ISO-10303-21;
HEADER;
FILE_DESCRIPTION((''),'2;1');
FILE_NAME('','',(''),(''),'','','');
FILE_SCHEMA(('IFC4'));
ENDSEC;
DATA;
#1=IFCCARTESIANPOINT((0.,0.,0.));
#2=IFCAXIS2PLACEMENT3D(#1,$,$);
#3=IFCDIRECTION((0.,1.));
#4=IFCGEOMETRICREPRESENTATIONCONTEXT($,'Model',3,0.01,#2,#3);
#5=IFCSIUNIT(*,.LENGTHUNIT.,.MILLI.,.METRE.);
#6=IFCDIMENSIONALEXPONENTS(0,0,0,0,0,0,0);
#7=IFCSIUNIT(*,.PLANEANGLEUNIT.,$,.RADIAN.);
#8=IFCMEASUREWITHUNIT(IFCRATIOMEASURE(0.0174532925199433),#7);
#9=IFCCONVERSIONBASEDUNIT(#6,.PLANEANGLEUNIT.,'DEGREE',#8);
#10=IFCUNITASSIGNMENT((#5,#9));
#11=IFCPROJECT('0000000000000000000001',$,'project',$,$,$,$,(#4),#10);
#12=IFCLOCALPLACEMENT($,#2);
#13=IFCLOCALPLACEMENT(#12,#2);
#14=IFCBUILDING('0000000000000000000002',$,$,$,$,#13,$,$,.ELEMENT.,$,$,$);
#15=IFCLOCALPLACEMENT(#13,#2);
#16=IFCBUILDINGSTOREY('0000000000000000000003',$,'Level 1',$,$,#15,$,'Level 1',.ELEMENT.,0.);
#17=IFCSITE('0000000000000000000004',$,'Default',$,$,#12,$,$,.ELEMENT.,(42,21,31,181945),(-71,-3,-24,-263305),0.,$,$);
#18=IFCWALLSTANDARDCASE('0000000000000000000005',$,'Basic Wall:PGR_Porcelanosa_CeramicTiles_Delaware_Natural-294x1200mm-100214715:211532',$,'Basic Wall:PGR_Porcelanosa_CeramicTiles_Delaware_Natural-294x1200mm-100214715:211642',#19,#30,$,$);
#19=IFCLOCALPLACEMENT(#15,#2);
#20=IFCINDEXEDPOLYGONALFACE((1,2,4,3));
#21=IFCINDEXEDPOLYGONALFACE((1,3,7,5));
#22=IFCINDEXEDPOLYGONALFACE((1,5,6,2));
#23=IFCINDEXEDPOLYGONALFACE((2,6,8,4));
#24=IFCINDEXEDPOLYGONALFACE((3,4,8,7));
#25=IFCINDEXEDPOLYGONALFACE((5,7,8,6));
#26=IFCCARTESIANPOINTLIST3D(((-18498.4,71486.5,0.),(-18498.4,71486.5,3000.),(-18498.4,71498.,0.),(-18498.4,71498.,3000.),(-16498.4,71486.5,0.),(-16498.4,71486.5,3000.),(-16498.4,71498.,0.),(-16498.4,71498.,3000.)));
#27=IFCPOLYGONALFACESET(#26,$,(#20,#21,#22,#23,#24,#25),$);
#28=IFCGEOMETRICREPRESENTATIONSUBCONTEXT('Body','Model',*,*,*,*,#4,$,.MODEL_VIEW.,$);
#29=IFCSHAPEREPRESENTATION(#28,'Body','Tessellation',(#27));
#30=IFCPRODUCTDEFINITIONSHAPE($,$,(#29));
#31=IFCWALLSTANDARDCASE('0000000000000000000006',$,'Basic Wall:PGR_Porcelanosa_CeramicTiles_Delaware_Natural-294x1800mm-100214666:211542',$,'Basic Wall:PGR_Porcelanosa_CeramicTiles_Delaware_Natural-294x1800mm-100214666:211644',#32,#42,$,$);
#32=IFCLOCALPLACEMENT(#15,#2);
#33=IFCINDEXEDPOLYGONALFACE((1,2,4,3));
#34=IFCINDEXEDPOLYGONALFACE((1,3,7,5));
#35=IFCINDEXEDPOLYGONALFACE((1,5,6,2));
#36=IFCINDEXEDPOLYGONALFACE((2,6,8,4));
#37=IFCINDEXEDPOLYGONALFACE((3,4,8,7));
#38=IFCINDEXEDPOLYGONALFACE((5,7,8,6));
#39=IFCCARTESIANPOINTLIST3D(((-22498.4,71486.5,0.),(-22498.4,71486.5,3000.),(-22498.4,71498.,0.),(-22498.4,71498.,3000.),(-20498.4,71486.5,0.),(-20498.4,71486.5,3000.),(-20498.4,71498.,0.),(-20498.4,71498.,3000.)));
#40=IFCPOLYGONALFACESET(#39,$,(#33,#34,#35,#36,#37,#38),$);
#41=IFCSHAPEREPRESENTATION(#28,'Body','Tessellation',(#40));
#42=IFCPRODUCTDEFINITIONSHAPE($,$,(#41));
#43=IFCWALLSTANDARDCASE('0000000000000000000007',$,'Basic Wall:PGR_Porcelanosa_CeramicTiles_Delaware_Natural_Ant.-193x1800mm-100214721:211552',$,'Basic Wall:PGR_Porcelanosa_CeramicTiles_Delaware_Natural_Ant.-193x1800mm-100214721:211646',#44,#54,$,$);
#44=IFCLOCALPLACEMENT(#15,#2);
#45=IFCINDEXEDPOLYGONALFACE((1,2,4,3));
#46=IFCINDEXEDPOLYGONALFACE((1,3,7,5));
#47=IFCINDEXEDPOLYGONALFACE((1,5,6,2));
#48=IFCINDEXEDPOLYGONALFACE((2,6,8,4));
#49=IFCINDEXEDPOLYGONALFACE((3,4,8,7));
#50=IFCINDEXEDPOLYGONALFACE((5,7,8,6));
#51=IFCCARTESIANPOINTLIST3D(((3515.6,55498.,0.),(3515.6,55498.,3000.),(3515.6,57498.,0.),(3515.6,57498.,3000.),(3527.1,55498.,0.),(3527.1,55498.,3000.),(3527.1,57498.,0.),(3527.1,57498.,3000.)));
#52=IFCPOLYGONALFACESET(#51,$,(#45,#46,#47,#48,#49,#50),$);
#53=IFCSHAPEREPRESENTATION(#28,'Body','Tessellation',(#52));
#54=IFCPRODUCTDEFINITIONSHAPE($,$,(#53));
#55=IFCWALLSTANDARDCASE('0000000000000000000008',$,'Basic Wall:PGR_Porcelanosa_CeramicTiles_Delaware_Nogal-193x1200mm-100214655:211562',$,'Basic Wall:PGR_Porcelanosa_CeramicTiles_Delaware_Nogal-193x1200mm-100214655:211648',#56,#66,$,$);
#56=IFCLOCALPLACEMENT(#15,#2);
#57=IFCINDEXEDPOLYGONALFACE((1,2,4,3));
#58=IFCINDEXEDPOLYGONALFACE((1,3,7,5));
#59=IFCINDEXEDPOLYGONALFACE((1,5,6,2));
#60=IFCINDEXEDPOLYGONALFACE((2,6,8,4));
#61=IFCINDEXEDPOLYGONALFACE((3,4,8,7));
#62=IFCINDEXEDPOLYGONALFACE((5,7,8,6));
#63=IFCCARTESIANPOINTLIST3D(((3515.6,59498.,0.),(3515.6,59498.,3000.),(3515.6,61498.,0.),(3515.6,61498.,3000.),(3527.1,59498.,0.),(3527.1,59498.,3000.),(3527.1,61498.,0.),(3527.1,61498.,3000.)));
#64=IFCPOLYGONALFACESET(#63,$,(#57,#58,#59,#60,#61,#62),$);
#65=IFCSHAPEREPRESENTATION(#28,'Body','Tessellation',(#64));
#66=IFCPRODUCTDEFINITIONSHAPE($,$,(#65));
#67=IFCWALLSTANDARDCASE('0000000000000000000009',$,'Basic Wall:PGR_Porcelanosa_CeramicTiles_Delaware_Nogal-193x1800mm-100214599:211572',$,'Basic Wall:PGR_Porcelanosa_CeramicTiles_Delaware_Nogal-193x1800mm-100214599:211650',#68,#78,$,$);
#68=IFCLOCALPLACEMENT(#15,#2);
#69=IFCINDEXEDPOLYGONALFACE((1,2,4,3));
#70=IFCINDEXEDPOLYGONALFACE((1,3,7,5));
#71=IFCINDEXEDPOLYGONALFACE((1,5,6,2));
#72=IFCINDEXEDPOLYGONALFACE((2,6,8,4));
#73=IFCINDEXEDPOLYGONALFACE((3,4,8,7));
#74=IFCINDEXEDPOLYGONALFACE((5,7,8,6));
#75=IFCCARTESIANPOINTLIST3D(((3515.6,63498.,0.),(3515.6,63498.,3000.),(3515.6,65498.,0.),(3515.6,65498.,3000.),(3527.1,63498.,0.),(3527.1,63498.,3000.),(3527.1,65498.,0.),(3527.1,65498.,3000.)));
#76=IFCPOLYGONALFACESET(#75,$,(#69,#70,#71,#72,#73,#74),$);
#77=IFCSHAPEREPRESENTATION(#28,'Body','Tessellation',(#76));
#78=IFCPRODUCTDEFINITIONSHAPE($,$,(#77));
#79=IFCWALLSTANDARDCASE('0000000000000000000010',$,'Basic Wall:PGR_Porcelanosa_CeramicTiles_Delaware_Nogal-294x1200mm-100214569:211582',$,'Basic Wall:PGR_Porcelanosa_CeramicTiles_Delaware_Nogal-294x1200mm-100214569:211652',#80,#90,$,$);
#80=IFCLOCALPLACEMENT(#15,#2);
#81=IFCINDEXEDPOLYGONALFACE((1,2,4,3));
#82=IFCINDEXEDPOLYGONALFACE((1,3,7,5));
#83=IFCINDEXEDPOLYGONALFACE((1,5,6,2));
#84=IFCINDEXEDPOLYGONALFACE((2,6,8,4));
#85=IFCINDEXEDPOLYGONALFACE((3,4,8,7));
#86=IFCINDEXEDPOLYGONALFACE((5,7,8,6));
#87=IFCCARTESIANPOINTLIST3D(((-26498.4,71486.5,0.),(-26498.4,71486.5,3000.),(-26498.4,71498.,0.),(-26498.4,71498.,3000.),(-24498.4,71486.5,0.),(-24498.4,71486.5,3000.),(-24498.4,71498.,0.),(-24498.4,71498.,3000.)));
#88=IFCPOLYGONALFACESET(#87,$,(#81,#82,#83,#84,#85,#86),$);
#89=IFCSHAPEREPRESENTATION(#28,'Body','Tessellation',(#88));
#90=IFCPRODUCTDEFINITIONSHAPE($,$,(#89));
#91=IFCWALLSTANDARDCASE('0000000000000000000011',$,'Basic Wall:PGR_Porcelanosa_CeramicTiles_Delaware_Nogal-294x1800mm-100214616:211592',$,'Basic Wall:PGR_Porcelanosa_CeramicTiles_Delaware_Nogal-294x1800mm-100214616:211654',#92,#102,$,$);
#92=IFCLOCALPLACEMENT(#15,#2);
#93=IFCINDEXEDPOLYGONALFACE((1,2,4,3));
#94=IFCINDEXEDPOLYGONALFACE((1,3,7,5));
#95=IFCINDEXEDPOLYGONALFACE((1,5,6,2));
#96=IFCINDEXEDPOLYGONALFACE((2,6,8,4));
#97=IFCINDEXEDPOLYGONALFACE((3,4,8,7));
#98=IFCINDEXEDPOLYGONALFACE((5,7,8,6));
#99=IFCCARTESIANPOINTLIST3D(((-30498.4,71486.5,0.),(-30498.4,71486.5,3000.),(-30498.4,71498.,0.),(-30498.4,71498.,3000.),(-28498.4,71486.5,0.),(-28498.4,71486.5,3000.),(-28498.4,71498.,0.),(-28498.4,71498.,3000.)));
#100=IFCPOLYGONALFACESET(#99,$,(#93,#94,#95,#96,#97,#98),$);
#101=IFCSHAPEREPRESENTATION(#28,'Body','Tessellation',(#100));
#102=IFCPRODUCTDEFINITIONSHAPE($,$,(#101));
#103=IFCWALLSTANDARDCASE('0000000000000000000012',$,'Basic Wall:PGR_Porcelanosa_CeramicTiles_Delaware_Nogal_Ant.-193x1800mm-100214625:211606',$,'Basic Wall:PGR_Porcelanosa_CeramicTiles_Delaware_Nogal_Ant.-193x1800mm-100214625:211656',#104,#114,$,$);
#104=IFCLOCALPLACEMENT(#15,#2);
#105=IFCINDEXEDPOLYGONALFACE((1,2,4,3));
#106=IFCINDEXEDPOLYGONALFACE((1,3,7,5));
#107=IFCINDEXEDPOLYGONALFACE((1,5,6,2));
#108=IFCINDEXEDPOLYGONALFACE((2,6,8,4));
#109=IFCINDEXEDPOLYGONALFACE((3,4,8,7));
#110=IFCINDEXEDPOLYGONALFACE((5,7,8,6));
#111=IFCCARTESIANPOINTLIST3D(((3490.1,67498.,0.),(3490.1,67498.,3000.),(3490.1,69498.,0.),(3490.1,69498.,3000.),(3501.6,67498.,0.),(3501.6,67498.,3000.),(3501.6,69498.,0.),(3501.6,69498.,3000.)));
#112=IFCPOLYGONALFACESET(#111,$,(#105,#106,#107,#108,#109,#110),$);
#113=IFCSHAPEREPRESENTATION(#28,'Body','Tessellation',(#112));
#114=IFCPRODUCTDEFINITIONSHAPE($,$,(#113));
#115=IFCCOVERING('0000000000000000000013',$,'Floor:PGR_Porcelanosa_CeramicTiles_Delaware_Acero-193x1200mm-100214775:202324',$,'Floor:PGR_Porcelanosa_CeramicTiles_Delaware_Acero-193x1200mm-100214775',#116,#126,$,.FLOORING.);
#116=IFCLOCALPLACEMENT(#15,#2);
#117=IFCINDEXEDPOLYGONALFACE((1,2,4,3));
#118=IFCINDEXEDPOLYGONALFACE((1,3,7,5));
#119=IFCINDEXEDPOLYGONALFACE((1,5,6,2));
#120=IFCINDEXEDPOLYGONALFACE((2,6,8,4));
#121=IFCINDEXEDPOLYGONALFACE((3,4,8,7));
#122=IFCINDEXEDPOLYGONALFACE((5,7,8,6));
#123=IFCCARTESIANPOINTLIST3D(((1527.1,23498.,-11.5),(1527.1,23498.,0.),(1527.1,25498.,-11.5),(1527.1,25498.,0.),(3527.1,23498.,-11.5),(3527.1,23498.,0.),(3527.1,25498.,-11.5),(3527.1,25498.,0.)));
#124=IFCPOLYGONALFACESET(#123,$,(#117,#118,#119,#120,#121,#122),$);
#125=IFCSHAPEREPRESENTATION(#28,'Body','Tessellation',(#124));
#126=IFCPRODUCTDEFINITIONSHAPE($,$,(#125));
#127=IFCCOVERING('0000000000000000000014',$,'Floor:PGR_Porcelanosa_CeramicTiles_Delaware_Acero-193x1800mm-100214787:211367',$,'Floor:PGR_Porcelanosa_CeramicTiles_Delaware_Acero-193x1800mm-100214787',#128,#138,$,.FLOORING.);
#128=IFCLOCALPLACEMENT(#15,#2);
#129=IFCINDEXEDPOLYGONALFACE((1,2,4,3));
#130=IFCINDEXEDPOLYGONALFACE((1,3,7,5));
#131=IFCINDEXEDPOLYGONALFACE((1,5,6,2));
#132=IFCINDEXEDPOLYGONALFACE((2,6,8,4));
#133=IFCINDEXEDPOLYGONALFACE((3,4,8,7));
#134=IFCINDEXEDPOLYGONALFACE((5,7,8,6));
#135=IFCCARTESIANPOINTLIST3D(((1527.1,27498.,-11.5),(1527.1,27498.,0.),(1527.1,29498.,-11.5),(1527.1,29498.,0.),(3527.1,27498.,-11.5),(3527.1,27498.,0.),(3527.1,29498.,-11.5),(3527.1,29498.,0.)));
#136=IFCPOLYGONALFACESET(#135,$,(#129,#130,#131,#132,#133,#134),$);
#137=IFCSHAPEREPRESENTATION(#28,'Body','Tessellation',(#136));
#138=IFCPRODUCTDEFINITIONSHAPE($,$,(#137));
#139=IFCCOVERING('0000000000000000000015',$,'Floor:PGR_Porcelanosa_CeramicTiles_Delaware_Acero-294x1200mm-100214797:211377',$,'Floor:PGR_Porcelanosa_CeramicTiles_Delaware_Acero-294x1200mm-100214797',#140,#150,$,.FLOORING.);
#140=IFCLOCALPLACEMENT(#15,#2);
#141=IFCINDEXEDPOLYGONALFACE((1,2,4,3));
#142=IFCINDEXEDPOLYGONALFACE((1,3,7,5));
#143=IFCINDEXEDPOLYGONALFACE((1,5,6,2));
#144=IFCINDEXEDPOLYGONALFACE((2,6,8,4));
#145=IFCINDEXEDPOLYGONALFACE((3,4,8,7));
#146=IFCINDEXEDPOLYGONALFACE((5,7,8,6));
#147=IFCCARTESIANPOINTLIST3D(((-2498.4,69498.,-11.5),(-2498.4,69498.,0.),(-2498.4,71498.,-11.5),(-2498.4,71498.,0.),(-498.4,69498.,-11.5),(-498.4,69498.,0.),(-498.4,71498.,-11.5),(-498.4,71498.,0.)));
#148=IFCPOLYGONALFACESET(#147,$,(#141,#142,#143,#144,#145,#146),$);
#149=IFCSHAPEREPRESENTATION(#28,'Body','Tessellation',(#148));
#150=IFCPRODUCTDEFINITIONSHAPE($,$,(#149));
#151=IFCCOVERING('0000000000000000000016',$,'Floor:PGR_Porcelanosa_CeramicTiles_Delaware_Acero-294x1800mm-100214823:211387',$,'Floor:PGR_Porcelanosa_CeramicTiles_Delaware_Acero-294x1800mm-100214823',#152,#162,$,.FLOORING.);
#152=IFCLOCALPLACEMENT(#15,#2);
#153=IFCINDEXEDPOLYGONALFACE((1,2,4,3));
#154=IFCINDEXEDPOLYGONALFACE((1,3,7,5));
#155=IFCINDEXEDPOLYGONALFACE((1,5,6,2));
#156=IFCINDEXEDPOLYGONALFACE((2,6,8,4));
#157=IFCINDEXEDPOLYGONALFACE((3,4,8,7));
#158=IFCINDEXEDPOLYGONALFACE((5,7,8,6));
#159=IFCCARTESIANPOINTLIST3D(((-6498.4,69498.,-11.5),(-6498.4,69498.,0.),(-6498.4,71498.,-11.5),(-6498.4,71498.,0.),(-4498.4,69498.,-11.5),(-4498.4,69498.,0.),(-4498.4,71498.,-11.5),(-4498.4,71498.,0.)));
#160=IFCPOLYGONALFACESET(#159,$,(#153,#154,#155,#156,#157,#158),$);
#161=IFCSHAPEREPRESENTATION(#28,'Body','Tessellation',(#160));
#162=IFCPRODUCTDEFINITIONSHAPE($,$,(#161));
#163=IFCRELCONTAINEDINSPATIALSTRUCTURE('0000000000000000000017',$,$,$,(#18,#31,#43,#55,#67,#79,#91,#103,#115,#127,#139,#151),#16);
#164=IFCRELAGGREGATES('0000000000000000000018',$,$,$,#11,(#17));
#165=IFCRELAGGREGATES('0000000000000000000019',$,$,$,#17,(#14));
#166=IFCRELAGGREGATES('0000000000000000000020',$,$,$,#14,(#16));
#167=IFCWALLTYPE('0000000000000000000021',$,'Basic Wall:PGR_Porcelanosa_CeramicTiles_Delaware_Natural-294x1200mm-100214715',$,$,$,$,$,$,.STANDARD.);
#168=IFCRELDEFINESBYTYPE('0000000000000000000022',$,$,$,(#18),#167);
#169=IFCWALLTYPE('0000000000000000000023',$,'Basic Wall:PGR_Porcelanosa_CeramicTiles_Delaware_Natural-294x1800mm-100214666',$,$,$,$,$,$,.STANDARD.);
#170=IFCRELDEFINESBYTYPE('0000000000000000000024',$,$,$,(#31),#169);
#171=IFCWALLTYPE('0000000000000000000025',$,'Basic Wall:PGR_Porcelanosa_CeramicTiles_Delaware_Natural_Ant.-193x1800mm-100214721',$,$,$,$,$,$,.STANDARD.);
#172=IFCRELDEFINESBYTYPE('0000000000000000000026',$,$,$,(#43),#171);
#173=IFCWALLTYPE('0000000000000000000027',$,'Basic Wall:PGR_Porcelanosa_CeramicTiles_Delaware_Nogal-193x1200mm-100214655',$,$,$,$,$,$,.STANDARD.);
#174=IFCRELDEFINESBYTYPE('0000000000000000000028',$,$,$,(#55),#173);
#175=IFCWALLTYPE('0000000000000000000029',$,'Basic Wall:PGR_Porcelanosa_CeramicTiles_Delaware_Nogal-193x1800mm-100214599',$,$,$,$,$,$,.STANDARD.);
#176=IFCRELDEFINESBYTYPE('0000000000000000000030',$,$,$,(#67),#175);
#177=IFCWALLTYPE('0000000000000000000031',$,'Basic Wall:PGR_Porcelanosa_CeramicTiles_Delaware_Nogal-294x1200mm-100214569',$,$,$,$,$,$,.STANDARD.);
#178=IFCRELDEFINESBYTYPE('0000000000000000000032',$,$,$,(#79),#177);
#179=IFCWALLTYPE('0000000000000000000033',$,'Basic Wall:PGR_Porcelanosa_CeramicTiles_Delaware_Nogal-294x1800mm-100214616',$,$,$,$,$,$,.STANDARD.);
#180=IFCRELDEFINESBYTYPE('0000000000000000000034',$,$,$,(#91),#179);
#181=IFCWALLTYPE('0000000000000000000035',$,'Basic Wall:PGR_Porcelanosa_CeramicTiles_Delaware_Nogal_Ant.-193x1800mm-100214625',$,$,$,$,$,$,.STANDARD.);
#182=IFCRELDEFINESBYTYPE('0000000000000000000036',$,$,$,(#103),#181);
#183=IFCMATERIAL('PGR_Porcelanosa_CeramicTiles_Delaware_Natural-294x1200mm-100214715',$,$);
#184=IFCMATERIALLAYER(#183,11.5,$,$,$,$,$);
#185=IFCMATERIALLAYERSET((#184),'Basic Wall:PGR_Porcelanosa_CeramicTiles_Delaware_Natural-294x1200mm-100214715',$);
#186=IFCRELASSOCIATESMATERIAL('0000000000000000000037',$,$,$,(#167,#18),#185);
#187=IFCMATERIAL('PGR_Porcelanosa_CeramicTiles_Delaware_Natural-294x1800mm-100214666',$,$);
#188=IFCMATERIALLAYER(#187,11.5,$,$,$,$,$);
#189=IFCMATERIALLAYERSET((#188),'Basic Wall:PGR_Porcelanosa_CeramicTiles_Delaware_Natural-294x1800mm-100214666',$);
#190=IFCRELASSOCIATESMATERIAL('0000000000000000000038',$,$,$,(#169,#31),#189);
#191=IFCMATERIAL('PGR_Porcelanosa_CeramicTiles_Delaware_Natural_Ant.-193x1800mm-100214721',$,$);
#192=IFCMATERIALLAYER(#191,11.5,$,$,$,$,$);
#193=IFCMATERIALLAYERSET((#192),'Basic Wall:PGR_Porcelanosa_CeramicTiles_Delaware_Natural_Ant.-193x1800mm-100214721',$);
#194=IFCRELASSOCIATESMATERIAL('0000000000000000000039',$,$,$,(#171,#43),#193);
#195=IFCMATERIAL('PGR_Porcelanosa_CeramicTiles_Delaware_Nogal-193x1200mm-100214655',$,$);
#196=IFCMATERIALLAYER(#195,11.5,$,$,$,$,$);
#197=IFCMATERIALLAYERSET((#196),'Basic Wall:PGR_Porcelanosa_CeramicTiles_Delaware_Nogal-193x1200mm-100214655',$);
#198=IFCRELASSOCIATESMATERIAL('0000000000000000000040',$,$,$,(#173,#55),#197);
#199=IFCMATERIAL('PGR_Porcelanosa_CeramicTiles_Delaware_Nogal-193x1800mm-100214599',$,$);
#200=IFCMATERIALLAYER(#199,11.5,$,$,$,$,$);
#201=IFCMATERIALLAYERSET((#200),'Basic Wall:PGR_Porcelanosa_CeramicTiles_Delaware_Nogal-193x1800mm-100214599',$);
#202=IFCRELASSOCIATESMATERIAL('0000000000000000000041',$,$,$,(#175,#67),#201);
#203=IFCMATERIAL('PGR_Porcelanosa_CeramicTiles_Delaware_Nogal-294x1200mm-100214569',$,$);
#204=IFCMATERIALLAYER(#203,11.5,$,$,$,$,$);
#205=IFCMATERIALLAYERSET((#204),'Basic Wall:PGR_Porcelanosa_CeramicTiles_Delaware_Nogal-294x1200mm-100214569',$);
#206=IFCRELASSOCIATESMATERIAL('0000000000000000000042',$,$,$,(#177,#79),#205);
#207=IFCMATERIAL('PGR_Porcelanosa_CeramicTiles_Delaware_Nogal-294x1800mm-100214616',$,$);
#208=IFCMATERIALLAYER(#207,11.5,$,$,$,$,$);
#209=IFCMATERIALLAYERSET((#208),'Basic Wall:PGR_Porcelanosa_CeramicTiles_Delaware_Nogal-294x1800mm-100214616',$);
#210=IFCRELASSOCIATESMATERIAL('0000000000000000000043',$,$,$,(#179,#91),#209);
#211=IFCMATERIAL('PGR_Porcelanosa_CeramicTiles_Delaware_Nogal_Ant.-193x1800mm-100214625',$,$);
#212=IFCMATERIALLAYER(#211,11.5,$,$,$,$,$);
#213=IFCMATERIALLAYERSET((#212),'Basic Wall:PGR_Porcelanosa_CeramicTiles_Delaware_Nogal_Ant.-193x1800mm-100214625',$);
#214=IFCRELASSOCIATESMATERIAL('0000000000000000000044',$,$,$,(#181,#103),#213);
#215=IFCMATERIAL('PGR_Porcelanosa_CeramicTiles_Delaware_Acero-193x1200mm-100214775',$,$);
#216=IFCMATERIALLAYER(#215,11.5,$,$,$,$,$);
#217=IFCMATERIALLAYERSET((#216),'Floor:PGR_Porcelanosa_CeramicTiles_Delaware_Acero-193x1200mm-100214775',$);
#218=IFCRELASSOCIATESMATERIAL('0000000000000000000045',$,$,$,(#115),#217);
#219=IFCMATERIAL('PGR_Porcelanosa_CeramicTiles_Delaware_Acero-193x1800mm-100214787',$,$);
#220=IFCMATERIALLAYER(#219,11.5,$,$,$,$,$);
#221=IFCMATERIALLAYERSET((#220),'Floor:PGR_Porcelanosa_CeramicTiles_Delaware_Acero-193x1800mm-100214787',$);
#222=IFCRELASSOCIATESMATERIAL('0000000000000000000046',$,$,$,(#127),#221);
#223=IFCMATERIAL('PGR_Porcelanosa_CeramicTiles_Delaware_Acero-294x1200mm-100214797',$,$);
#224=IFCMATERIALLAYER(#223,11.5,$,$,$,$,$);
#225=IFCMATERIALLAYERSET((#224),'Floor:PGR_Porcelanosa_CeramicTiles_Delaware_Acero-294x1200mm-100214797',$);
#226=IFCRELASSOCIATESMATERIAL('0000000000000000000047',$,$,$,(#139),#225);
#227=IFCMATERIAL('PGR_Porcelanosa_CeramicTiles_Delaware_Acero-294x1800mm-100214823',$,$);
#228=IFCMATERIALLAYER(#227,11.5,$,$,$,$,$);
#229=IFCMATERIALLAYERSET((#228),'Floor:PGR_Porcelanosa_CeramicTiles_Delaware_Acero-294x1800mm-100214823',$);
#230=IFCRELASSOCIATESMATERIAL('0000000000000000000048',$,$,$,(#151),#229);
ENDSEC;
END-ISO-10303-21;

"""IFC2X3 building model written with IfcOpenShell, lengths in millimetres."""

from ifc_helpers import new_model, entity, si_unit, converted_unit, direction, frame, frame_2d, origin, place, context, subcontext, project, spatial, rectangle, extrude, material, layer, layer_set, layer_usage, type_object, element, save


model = new_model("IFC2X3")

# Units and contexts
model_context = context("Model", 3, precision=0.01, world=origin(), true_north=direction((0.0, 1.0)))
body_context = subcontext(model_context, "Body", "Model", "MODEL_VIEW")
ifc_project = project(units=[si_unit("LENGTHUNIT", "METRE", prefix="MILLI"), converted_unit("PLANEANGLEUNIT", "DEGREE", entity("IfcRatioMeasure", 0.0174532925199433), si_unit("PLANEANGLEUNIT", "RADIAN"), dimensions=[0, 0, 0, 0, 0, 0, 0])], contexts=[model_context])

# Site, building, storey
site_placement = place(None, origin())
site = spatial("IfcSite", under=ifc_project, at=site_placement, Name="Default", CompositionType="ELEMENT", RefLatitude=(42, 21, 31, 181945), RefLongitude=(-71, -3, -24, -263305), RefElevation=0.0)
building_placement = place(site_placement, origin())
building = spatial("IfcBuilding", under=site, at=building_placement, CompositionType="ELEMENT")
storey_placement = place(building_placement, origin())
storey = spatial("IfcBuildingStorey", under=building, at=storey_placement, Name="Level 1", LongName="Level 1", CompositionType="ELEMENT", Elevation=0.0)

# Walls
ifc_material_1 = material(Name="PGR_Porcelanosa_CeramicTiles_Delaware_Acero-193x1200mm-100214775")
ifc_material_2 = material(Name="PGR_Porcelanosa_CeramicTiles_Delaware_Acero-193x1800mm-100214787")
ifc_material_3 = material(Name="PGR_Porcelanosa_CeramicTiles_Delaware_Acero-294x1200mm-100214797")
ifc_material_4 = material(Name="PGR_Porcelanosa_CeramicTiles_Delaware_Acero-294x1800mm-100214823")
ifc_material_5 = material(Name="PGR_Porcelanosa_CeramicTiles_Delaware_Natural-294x1200mm-100214715")
ifc_layer_1 = layer(ifc_material_5, 11.5)
ifc_layer_set_1 = layer_set([ifc_layer_1], Name="Basic Wall:PGR_Porcelanosa_CeramicTiles_Delaware_Natural-294x1200mm-100214715")
ifc_layer_usage_1 = layer_usage(ifc_layer_set_1, "AXIS2", "POSITIVE", -5.8)
wall_type_1 = type_object("IfcWallType", Name="Basic Wall:PGR_Porcelanosa_CeramicTiles_Delaware_Natural-294x1200mm-100214715", PredefinedType="STANDARD", material=ifc_layer_set_1)
wall_1_placement = place(storey_placement, frame((-18498.4, 71492.3, 0.0)))
element("IfcWallStandardCase", 1, at=wall_1_placement, inside=storey, type_object=wall_type_1, material=ifc_layer_usage_1, Name="Basic Wall:PGR_Porcelanosa_CeramicTiles_Delaware_Natural-294x1200mm-100214715:211532", ObjectType="Basic Wall:PGR_Porcelanosa_CeramicTiles_Delaware_Natural-294x1200mm-100214715:211642", context=body_context, shape_type="SweptSolid", body=[
    extrude(rectangle(XDim=2000.0, YDim=11.5, at=frame_2d((1000.0, 0.0), x_axis=(-1.0, 0.0))), origin(), (0.0, 0.0, 1.0), 3000.0),
])
ifc_material_6 = material(Name="PGR_Porcelanosa_CeramicTiles_Delaware_Natural-294x1800mm-100214666")
ifc_layer_2 = layer(ifc_material_6, 11.5)
ifc_layer_set_2 = layer_set([ifc_layer_2], Name="Basic Wall:PGR_Porcelanosa_CeramicTiles_Delaware_Natural-294x1800mm-100214666")
ifc_layer_usage_2 = layer_usage(ifc_layer_set_2, "AXIS2", "POSITIVE", -5.8)
wall_type_2 = type_object("IfcWallType", Name="Basic Wall:PGR_Porcelanosa_CeramicTiles_Delaware_Natural-294x1800mm-100214666", PredefinedType="STANDARD", material=ifc_layer_set_2)
wall_2_placement = place(storey_placement, frame((-22498.4, 71492.3, 0.0)))
element("IfcWallStandardCase", 2, at=wall_2_placement, inside=storey, type_object=wall_type_2, material=ifc_layer_usage_2, Name="Basic Wall:PGR_Porcelanosa_CeramicTiles_Delaware_Natural-294x1800mm-100214666:211542", ObjectType="Basic Wall:PGR_Porcelanosa_CeramicTiles_Delaware_Natural-294x1800mm-100214666:211644", context=body_context, shape_type="SweptSolid", body=[
    extrude(rectangle(XDim=2000.0, YDim=11.5, at=frame_2d((1000.0, 0.0), x_axis=(-1.0, 0.0))), origin(), (0.0, 0.0, 1.0), 3000.0),
])
ifc_material_7 = material(Name="PGR_Porcelanosa_CeramicTiles_Delaware_Natural_Ant.-193x1800mm-100214721")
ifc_layer_3 = layer(ifc_material_7, 11.5)
ifc_layer_set_3 = layer_set([ifc_layer_3], Name="Basic Wall:PGR_Porcelanosa_CeramicTiles_Delaware_Natural_Ant.-193x1800mm-100214721")
ifc_layer_usage_3 = layer_usage(ifc_layer_set_3, "AXIS2", "POSITIVE", -5.8)
wall_type_3 = type_object("IfcWallType", Name="Basic Wall:PGR_Porcelanosa_CeramicTiles_Delaware_Natural_Ant.-193x1800mm-100214721", PredefinedType="STANDARD", material=ifc_layer_set_3)
wall_3_placement = place(storey_placement, frame((3521.3, 57498.0, 0.0), z_axis=(0.0, 0.0, 1.0), x_axis=(0.0, -1.0, 0.0)))
element("IfcWallStandardCase", 3, at=wall_3_placement, inside=storey, type_object=wall_type_3, material=ifc_layer_usage_3, Name="Basic Wall:PGR_Porcelanosa_CeramicTiles_Delaware_Natural_Ant.-193x1800mm-100214721:211552", ObjectType="Basic Wall:PGR_Porcelanosa_CeramicTiles_Delaware_Natural_Ant.-193x1800mm-100214721:211646", context=body_context, shape_type="SweptSolid", body=[
    extrude(rectangle(XDim=2000.0, YDim=11.5, at=frame_2d((1000.0, 0.0), x_axis=(-1.0, 0.0))), origin(), (0.0, 0.0, 1.0), 3000.0),
])
ifc_material_8 = material(Name="PGR_Porcelanosa_CeramicTiles_Delaware_Nogal-193x1200mm-100214655")
ifc_layer_4 = layer(ifc_material_8, 11.5)
ifc_layer_set_4 = layer_set([ifc_layer_4], Name="Basic Wall:PGR_Porcelanosa_CeramicTiles_Delaware_Nogal-193x1200mm-100214655")
ifc_layer_usage_4 = layer_usage(ifc_layer_set_4, "AXIS2", "POSITIVE", -5.8)
wall_type_4 = type_object("IfcWallType", Name="Basic Wall:PGR_Porcelanosa_CeramicTiles_Delaware_Nogal-193x1200mm-100214655", PredefinedType="STANDARD", material=ifc_layer_set_4)
wall_4_placement = place(storey_placement, frame((3521.3, 61498.0, 0.0), z_axis=(0.0, 0.0, 1.0), x_axis=(0.0, -1.0, 0.0)))
element("IfcWallStandardCase", 4, at=wall_4_placement, inside=storey, type_object=wall_type_4, material=ifc_layer_usage_4, Name="Basic Wall:PGR_Porcelanosa_CeramicTiles_Delaware_Nogal-193x1200mm-100214655:211562", ObjectType="Basic Wall:PGR_Porcelanosa_CeramicTiles_Delaware_Nogal-193x1200mm-100214655:211648", context=body_context, shape_type="SweptSolid", body=[
    extrude(rectangle(XDim=2000.0, YDim=11.5, at=frame_2d((1000.0, 0.0), x_axis=(-1.0, 0.0))), origin(), (0.0, 0.0, 1.0), 3000.0),
])
ifc_material_9 = material(Name="PGR_Porcelanosa_CeramicTiles_Delaware_Nogal-193x1800mm-100214599")
ifc_layer_5 = layer(ifc_material_9, 11.5)
ifc_layer_set_5 = layer_set([ifc_layer_5], Name="Basic Wall:PGR_Porcelanosa_CeramicTiles_Delaware_Nogal-193x1800mm-100214599")
ifc_layer_usage_5 = layer_usage(ifc_layer_set_5, "AXIS2", "POSITIVE", -5.8)
wall_type_5 = type_object("IfcWallType", Name="Basic Wall:PGR_Porcelanosa_CeramicTiles_Delaware_Nogal-193x1800mm-100214599", PredefinedType="STANDARD", material=ifc_layer_set_5)
wall_5_placement = place(storey_placement, frame((3521.3, 65498.0, 0.0), z_axis=(0.0, 0.0, 1.0), x_axis=(0.0, -1.0, 0.0)))
element("IfcWallStandardCase", 5, at=wall_5_placement, inside=storey, type_object=wall_type_5, material=ifc_layer_usage_5, Name="Basic Wall:PGR_Porcelanosa_CeramicTiles_Delaware_Nogal-193x1800mm-100214599:211572", ObjectType="Basic Wall:PGR_Porcelanosa_CeramicTiles_Delaware_Nogal-193x1800mm-100214599:211650", context=body_context, shape_type="SweptSolid", body=[
    extrude(rectangle(XDim=2000.0, YDim=11.5, at=frame_2d((1000.0, 0.0), x_axis=(-1.0, 0.0))), origin(), (0.0, 0.0, 1.0), 3000.0),
])
ifc_material_10 = material(Name="PGR_Porcelanosa_CeramicTiles_Delaware_Nogal-294x1200mm-100214569")
ifc_layer_6 = layer(ifc_material_10, 11.5)
ifc_layer_set_6 = layer_set([ifc_layer_6], Name="Basic Wall:PGR_Porcelanosa_CeramicTiles_Delaware_Nogal-294x1200mm-100214569")
ifc_layer_usage_6 = layer_usage(ifc_layer_set_6, "AXIS2", "POSITIVE", -5.8)
wall_type_6 = type_object("IfcWallType", Name="Basic Wall:PGR_Porcelanosa_CeramicTiles_Delaware_Nogal-294x1200mm-100214569", PredefinedType="STANDARD", material=ifc_layer_set_6)
wall_6_placement = place(storey_placement, frame((-26498.4, 71492.3, 0.0)))
element("IfcWallStandardCase", 6, at=wall_6_placement, inside=storey, type_object=wall_type_6, material=ifc_layer_usage_6, Name="Basic Wall:PGR_Porcelanosa_CeramicTiles_Delaware_Nogal-294x1200mm-100214569:211582", ObjectType="Basic Wall:PGR_Porcelanosa_CeramicTiles_Delaware_Nogal-294x1200mm-100214569:211652", context=body_context, shape_type="SweptSolid", body=[
    extrude(rectangle(XDim=2000.0, YDim=11.5, at=frame_2d((1000.0, 0.0), x_axis=(-1.0, 0.0))), origin(), (0.0, 0.0, 1.0), 3000.0),
])
ifc_material_11 = material(Name="PGR_Porcelanosa_CeramicTiles_Delaware_Nogal-294x1800mm-100214616")
ifc_layer_7 = layer(ifc_material_11, 11.5)
ifc_layer_set_7 = layer_set([ifc_layer_7], Name="Basic Wall:PGR_Porcelanosa_CeramicTiles_Delaware_Nogal-294x1800mm-100214616")
ifc_layer_usage_7 = layer_usage(ifc_layer_set_7, "AXIS2", "POSITIVE", -5.8)
wall_type_7 = type_object("IfcWallType", Name="Basic Wall:PGR_Porcelanosa_CeramicTiles_Delaware_Nogal-294x1800mm-100214616", PredefinedType="STANDARD", material=ifc_layer_set_7)
wall_7_placement = place(storey_placement, frame((-30498.4, 71492.3, 0.0)))
element("IfcWallStandardCase", 7, at=wall_7_placement, inside=storey, type_object=wall_type_7, material=ifc_layer_usage_7, Name="Basic Wall:PGR_Porcelanosa_CeramicTiles_Delaware_Nogal-294x1800mm-100214616:211592", ObjectType="Basic Wall:PGR_Porcelanosa_CeramicTiles_Delaware_Nogal-294x1800mm-100214616:211654", context=body_context, shape_type="SweptSolid", body=[
    extrude(rectangle(XDim=2000.0, YDim=11.5, at=frame_2d((1000.0, 0.0), x_axis=(-1.0, 0.0))), origin(), (0.0, 0.0, 1.0), 3000.0),
])
ifc_material_12 = material(Name="PGR_Porcelanosa_CeramicTiles_Delaware_Nogal_Ant.-193x1800mm-100214625")
ifc_layer_8 = layer(ifc_material_12, 11.5)
ifc_layer_set_8 = layer_set([ifc_layer_8], Name="Basic Wall:PGR_Porcelanosa_CeramicTiles_Delaware_Nogal_Ant.-193x1800mm-100214625")
ifc_layer_usage_8 = layer_usage(ifc_layer_set_8, "AXIS2", "POSITIVE", -5.8)
wall_type_8 = type_object("IfcWallType", Name="Basic Wall:PGR_Porcelanosa_CeramicTiles_Delaware_Nogal_Ant.-193x1800mm-100214625", PredefinedType="STANDARD", material=ifc_layer_set_8)
wall_8_placement = place(storey_placement, frame((3495.8, 69498.0, 0.0), z_axis=(0.0, 0.0, 1.0), x_axis=(0.0, -1.0, 0.0)))
element("IfcWallStandardCase", 8, at=wall_8_placement, inside=storey, type_object=wall_type_8, material=ifc_layer_usage_8, Name="Basic Wall:PGR_Porcelanosa_CeramicTiles_Delaware_Nogal_Ant.-193x1800mm-100214625:211606", ObjectType="Basic Wall:PGR_Porcelanosa_CeramicTiles_Delaware_Nogal_Ant.-193x1800mm-100214625:211656", context=body_context, shape_type="SweptSolid", body=[
    extrude(rectangle(XDim=2000.0, YDim=11.5, at=frame_2d((1000.0, 0.0), x_axis=(-1.0, 0.0))), origin(), (0.0, 0.0, 1.0), 3000.0),
])

# Coverings
ifc_layer_9 = layer(ifc_material_1, 11.5)
ifc_layer_set_9 = layer_set([ifc_layer_9], Name="Floor:PGR_Porcelanosa_CeramicTiles_Delaware_Acero-193x1200mm-100214775")
ifc_layer_usage_9 = layer_usage(ifc_layer_set_9, "AXIS3", "POSITIVE", 0.0)
covering_1_placement = place(storey_placement, origin())
element("IfcCovering", 9, at=covering_1_placement, inside=storey, material=ifc_layer_usage_9, Name="Floor:PGR_Porcelanosa_CeramicTiles_Delaware_Acero-193x1200mm-100214775:202324", ObjectType="Floor:PGR_Porcelanosa_CeramicTiles_Delaware_Acero-193x1200mm-100214775", PredefinedType="FLOORING", context=body_context, shape_type="SweptSolid", body=[
    extrude(rectangle(XDim=2000.0, YDim=2000.0, at=frame_2d((0.0, 0.0), x_axis=(1.0, 0.0))), frame((2527.1, 24498.0, 0.0), z_axis=(0.0, 0.0, -1.0), x_axis=(0.0, 1.0, 0.0)), (0.0, 0.0, 1.0), 11.5),
])
ifc_layer_10 = layer(ifc_material_2, 11.5)
ifc_layer_set_10 = layer_set([ifc_layer_10], Name="Floor:PGR_Porcelanosa_CeramicTiles_Delaware_Acero-193x1800mm-100214787")
ifc_layer_usage_10 = layer_usage(ifc_layer_set_10, "AXIS3", "POSITIVE", 0.0)
covering_2_placement = place(storey_placement, origin())
element("IfcCovering", 10, at=covering_2_placement, inside=storey, material=ifc_layer_usage_10, Name="Floor:PGR_Porcelanosa_CeramicTiles_Delaware_Acero-193x1800mm-100214787:211367", ObjectType="Floor:PGR_Porcelanosa_CeramicTiles_Delaware_Acero-193x1800mm-100214787", PredefinedType="FLOORING", context=body_context, shape_type="SweptSolid", body=[
    extrude(rectangle(XDim=2000.0, YDim=2000.0, at=frame_2d((0.0, 0.0), x_axis=(1.0, 0.0))), frame((2527.1, 28498.0, 0.0), z_axis=(0.0, 0.0, -1.0), x_axis=(0.0, 1.0, 0.0)), (0.0, 0.0, 1.0), 11.5),
])
ifc_layer_11 = layer(ifc_material_3, 11.5)
ifc_layer_set_11 = layer_set([ifc_layer_11], Name="Floor:PGR_Porcelanosa_CeramicTiles_Delaware_Acero-294x1200mm-100214797")
ifc_layer_usage_11 = layer_usage(ifc_layer_set_11, "AXIS3", "POSITIVE", 0.0)
covering_3_placement = place(storey_placement, origin())
element("IfcCovering", 11, at=covering_3_placement, inside=storey, material=ifc_layer_usage_11, Name="Floor:PGR_Porcelanosa_CeramicTiles_Delaware_Acero-294x1200mm-100214797:211377", ObjectType="Floor:PGR_Porcelanosa_CeramicTiles_Delaware_Acero-294x1200mm-100214797", PredefinedType="FLOORING", context=body_context, shape_type="SweptSolid", body=[
    extrude(rectangle(XDim=2000.0, YDim=2000.0, at=frame_2d((0.0, 0.0), x_axis=(1.0, 0.0))), frame((-1498.4, 70498.0, 0.0), z_axis=(0.0, 0.0, -1.0), x_axis=(0.0, 1.0, 0.0)), (0.0, 0.0, 1.0), 11.5),
])
ifc_layer_12 = layer(ifc_material_4, 11.5)
ifc_layer_set_12 = layer_set([ifc_layer_12], Name="Floor:PGR_Porcelanosa_CeramicTiles_Delaware_Acero-294x1800mm-100214823")
ifc_layer_usage_12 = layer_usage(ifc_layer_set_12, "AXIS3", "POSITIVE", 0.0)
covering_4_placement = place(storey_placement, origin())
element("IfcCovering", 12, at=covering_4_placement, inside=storey, material=ifc_layer_usage_12, Name="Floor:PGR_Porcelanosa_CeramicTiles_Delaware_Acero-294x1800mm-100214823:211387", ObjectType="Floor:PGR_Porcelanosa_CeramicTiles_Delaware_Acero-294x1800mm-100214823", PredefinedType="FLOORING", context=body_context, shape_type="SweptSolid", body=[
    extrude(rectangle(XDim=2000.0, YDim=2000.0, at=frame_2d((0.0, 0.0), x_axis=(1.0, 0.0))), frame((-5498.4, 70498.0, 0.0), z_axis=(0.0, 0.0, -1.0), x_axis=(0.0, 1.0, 0.0)), (0.0, 0.0, 1.0), 11.5),
])

save(model, "model.ifc")
